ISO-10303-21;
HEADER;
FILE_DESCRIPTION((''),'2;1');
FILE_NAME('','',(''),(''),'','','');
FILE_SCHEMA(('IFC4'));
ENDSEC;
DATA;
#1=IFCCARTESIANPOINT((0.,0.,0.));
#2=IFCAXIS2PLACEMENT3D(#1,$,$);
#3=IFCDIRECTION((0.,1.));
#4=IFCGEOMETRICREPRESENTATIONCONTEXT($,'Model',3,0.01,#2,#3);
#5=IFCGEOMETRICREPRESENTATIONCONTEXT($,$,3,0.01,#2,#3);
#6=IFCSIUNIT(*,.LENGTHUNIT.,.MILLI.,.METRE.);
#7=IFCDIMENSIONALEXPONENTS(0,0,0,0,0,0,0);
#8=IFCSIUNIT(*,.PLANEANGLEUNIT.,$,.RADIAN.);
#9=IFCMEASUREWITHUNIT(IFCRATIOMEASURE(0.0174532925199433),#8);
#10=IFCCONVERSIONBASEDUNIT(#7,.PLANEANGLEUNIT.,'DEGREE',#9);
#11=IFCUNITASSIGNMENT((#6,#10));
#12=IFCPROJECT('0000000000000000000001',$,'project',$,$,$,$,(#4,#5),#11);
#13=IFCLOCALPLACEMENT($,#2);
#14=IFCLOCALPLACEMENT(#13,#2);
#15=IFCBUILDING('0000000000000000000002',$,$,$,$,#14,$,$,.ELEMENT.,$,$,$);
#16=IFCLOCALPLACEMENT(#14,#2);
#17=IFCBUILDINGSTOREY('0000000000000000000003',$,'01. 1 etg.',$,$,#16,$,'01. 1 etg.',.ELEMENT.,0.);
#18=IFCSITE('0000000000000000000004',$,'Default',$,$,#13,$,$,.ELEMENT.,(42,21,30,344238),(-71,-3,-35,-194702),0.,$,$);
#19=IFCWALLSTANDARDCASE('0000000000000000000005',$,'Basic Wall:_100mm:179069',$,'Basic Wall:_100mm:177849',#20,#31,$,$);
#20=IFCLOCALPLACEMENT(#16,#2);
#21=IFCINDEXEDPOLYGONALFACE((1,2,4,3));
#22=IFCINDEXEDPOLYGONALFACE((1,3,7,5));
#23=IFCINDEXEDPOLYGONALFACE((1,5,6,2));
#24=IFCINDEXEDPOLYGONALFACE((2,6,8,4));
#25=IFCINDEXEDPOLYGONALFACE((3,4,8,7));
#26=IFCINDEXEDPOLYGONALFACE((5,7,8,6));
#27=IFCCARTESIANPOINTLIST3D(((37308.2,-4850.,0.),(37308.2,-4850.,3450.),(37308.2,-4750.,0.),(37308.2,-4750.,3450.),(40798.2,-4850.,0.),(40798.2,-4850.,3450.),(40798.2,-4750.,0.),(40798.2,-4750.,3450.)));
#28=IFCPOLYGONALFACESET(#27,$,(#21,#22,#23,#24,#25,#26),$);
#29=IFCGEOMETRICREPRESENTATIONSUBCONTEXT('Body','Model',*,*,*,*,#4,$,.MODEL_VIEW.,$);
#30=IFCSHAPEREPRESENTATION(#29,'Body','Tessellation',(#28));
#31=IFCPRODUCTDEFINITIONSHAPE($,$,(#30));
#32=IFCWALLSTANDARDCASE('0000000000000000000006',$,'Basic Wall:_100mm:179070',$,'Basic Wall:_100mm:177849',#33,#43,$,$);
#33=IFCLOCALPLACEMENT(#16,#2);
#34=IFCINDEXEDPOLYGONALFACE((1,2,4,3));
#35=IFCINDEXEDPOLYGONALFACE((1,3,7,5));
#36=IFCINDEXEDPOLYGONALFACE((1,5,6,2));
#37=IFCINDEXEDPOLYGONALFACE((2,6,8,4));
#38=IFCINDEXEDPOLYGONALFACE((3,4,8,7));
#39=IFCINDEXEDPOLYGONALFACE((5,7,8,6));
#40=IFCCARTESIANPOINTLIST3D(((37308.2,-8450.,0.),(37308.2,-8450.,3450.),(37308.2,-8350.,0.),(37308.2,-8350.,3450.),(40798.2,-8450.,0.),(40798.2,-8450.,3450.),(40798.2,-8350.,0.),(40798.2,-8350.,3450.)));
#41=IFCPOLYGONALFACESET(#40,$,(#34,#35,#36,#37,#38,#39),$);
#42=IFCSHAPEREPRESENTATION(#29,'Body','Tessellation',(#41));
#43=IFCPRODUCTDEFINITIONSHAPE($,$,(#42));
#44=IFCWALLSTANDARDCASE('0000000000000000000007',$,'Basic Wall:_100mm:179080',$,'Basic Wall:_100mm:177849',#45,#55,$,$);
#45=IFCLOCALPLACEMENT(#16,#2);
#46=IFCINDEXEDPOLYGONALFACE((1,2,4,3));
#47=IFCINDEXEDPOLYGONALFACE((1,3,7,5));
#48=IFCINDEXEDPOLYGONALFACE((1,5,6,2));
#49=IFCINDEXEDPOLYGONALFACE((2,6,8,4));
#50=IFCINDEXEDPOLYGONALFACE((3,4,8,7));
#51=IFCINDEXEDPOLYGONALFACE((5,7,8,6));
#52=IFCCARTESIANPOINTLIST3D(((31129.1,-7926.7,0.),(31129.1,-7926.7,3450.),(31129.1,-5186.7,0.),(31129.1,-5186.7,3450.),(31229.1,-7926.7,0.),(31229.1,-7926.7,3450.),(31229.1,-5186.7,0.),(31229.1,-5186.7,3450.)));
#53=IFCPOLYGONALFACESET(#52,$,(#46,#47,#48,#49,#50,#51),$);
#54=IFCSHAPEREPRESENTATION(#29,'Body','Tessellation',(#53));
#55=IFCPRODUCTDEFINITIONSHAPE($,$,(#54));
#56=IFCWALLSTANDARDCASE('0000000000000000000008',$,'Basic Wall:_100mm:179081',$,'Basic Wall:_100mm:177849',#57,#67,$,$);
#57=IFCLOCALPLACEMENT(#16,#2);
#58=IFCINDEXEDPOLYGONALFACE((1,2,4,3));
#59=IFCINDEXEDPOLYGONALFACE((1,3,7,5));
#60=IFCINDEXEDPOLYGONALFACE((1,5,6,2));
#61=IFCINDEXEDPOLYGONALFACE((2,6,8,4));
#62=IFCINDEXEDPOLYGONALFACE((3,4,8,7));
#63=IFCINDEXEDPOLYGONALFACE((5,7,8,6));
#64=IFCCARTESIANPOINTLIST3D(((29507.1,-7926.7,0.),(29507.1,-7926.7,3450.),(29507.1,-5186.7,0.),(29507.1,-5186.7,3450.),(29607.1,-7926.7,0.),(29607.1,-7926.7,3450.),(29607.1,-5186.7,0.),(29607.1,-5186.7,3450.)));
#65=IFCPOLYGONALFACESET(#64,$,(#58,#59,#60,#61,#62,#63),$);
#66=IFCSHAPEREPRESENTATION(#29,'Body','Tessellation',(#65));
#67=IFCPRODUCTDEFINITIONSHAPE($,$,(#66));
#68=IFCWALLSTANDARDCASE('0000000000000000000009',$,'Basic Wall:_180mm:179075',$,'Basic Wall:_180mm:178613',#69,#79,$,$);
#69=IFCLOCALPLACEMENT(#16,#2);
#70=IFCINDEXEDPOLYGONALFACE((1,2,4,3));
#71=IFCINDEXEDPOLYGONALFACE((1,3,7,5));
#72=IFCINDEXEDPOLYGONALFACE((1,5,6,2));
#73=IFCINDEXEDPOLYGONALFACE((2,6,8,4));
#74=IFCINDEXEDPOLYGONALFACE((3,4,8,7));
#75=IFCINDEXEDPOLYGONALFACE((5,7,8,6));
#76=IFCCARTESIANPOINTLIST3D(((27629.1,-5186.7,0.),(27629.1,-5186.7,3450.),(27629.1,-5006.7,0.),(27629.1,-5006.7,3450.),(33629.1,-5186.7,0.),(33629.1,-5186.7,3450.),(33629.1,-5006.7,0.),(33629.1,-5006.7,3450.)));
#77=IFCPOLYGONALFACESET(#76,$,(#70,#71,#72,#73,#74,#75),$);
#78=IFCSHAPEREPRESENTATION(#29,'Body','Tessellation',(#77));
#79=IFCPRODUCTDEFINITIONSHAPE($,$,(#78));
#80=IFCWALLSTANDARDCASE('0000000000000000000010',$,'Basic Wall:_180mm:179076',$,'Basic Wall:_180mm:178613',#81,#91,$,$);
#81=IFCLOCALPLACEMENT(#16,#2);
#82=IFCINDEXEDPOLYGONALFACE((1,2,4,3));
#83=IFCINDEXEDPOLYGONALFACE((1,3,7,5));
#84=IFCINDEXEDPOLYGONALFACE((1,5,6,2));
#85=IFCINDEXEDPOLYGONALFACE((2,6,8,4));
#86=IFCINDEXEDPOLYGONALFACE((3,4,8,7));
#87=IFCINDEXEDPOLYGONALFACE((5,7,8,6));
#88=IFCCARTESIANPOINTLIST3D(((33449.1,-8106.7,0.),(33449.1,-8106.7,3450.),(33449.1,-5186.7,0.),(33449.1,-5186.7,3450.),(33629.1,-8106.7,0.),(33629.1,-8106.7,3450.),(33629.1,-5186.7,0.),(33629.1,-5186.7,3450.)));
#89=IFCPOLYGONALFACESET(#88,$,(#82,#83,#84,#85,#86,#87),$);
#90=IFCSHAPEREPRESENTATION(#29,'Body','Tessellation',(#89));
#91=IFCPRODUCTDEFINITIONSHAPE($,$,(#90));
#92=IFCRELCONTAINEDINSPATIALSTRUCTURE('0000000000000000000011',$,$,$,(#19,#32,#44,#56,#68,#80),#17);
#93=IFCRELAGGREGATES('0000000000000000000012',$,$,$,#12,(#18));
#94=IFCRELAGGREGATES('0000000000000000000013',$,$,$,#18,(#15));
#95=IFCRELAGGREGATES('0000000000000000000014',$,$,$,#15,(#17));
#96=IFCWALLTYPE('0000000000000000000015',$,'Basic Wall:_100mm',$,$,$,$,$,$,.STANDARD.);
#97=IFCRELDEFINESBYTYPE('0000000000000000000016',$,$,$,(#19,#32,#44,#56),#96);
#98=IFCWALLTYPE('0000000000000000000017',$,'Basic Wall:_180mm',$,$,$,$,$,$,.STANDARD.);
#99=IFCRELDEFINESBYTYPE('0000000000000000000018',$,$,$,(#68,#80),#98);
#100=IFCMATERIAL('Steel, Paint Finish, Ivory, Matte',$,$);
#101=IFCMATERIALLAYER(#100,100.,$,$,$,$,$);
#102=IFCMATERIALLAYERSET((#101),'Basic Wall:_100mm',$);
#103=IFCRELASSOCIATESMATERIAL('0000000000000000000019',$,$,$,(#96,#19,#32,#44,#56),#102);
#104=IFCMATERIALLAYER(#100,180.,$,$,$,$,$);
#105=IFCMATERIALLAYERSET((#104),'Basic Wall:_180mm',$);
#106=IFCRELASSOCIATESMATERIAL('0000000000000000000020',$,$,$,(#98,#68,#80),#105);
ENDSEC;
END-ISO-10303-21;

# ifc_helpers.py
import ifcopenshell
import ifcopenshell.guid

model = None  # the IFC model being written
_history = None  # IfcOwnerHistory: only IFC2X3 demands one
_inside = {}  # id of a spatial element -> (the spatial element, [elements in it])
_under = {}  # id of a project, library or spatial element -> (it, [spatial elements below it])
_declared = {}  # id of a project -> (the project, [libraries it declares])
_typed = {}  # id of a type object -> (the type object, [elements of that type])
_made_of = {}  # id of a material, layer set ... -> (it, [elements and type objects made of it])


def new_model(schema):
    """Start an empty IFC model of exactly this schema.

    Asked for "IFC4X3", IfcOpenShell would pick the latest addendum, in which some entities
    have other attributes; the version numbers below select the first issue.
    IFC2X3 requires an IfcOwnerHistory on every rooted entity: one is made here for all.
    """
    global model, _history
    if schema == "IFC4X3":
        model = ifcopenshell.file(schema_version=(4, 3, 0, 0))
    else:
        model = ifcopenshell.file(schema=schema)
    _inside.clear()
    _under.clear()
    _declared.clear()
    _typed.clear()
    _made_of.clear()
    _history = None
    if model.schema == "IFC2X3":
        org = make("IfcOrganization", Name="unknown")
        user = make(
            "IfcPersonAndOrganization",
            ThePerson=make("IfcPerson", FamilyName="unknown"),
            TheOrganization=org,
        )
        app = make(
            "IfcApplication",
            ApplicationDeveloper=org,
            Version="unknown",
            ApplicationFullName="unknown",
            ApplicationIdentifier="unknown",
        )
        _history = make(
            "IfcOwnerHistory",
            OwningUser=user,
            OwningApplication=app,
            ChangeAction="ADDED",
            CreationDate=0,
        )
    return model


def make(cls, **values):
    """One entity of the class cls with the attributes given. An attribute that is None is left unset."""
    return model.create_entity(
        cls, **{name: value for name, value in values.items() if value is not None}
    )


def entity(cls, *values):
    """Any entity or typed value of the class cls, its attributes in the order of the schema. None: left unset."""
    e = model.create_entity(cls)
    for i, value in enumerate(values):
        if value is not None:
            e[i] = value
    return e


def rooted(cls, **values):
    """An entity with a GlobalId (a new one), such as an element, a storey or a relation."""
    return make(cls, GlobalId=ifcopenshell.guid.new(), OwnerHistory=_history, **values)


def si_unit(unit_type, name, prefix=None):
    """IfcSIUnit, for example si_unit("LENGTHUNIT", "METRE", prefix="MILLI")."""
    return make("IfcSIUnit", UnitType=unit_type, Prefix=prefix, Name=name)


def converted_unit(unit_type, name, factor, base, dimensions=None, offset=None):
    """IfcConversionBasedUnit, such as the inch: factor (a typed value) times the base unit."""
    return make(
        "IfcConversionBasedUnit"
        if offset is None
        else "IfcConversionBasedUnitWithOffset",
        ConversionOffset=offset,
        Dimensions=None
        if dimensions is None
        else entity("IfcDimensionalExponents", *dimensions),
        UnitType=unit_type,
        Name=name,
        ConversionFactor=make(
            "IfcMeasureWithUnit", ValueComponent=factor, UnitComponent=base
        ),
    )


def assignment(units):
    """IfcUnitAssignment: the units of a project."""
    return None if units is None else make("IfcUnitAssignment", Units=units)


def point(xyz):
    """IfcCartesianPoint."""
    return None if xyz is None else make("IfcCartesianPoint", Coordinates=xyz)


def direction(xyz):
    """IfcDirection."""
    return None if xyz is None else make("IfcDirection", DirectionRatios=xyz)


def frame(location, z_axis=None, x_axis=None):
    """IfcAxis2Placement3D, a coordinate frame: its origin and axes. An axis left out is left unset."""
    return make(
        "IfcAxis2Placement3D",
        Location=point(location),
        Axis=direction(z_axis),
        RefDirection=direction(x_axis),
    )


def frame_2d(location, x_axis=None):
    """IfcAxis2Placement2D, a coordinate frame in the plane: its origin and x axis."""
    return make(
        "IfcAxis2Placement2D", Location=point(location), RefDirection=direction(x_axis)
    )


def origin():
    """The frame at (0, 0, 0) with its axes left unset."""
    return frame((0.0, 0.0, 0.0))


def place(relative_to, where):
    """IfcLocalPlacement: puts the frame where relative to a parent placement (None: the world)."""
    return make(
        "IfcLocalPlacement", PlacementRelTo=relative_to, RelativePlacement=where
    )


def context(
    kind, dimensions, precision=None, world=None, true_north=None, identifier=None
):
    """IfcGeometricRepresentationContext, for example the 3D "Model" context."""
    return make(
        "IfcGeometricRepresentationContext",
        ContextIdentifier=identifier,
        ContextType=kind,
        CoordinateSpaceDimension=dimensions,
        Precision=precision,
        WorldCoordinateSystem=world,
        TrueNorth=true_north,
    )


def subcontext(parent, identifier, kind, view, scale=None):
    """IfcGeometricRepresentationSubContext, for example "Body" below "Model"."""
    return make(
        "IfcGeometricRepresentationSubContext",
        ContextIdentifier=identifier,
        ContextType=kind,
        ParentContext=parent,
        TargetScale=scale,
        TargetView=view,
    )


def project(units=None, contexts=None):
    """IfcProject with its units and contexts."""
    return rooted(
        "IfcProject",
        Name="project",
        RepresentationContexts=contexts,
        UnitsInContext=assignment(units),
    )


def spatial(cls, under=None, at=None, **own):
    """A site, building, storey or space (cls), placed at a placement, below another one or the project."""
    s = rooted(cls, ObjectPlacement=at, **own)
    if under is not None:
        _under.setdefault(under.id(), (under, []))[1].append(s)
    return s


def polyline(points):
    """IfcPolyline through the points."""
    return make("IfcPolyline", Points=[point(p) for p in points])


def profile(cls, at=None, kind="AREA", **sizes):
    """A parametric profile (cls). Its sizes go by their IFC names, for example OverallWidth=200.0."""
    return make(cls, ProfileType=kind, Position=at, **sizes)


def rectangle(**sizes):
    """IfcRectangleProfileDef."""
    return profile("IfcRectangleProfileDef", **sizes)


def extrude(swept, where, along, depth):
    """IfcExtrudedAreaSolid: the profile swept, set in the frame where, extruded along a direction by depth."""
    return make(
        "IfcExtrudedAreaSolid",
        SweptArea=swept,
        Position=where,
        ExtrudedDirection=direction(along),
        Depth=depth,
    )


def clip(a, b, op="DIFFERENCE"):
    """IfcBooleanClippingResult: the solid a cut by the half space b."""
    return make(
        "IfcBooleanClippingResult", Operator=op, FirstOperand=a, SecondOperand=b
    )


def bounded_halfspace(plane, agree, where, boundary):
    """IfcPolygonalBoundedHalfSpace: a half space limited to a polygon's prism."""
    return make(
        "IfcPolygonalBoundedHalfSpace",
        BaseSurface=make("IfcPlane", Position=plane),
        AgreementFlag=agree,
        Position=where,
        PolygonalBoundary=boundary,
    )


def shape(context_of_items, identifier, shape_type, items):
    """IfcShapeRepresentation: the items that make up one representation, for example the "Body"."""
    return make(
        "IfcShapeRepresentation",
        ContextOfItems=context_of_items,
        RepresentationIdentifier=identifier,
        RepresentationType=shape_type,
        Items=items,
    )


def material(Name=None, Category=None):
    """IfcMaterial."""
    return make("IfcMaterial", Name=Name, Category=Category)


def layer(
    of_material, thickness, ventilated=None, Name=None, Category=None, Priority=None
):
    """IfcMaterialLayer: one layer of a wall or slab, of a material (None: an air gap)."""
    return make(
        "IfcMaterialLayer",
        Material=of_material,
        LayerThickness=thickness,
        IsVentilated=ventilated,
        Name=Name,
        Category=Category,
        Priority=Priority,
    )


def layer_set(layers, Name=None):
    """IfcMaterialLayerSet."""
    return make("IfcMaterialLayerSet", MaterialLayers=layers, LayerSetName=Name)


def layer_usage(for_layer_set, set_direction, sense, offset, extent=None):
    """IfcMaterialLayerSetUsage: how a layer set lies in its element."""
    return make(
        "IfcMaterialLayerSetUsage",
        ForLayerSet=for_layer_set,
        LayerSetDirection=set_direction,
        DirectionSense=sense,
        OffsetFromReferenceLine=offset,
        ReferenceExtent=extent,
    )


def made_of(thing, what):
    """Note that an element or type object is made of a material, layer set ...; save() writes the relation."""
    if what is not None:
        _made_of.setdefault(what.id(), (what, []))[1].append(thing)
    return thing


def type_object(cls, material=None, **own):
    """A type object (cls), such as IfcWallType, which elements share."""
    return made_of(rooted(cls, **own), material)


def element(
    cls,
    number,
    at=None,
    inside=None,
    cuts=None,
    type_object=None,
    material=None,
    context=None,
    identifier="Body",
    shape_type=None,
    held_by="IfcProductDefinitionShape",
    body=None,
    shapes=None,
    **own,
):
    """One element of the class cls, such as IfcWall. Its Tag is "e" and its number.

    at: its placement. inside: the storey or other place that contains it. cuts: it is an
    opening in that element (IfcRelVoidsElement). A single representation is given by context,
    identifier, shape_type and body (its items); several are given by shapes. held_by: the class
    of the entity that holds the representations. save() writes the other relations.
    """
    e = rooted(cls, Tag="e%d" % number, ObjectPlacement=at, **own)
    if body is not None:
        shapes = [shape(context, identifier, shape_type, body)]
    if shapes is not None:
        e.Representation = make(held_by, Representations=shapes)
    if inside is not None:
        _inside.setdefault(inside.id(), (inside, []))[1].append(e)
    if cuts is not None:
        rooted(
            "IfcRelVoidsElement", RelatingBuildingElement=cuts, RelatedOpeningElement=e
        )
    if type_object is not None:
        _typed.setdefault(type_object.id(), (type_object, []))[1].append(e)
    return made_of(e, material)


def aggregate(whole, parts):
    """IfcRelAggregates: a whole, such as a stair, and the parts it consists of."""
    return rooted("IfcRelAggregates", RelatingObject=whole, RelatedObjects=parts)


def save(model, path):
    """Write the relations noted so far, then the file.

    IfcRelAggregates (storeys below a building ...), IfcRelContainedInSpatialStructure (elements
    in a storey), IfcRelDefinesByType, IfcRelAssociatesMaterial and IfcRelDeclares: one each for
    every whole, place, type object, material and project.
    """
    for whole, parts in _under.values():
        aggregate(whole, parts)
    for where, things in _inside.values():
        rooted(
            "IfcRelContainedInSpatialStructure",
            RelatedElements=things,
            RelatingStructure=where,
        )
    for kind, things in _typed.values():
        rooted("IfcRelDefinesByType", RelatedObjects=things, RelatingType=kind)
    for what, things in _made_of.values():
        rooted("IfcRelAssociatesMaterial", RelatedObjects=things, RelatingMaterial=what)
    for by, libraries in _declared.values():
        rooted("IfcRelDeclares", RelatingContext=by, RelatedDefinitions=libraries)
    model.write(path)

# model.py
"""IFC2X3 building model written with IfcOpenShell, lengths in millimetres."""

from ifc_helpers import new_model, entity, si_unit, converted_unit, direction, frame, frame_2d, origin, place, context, subcontext, project, spatial, polyline, rectangle, extrude, clip, bounded_halfspace, material, layer, layer_set, layer_usage, type_object, element, save


model = new_model("IFC2X3")

# Units and contexts
model_context = context("Model", 3, precision=0.01, world=origin(), true_north=direction((0.0, 1.0)))
context_of_model = context(None, 3, precision=0.01, world=origin(), true_north=direction((0.0, 1.0)))
body_context = subcontext(model_context, "Body", "Model", "MODEL_VIEW")
ifc_project = project(units=[si_unit("LENGTHUNIT", "METRE", prefix="MILLI"), converted_unit("PLANEANGLEUNIT", "DEGREE", entity("IfcRatioMeasure", 0.0174532925199433), si_unit("PLANEANGLEUNIT", "RADIAN"), dimensions=[0, 0, 0, 0, 0, 0, 0])], contexts=[model_context, context_of_model])

# Site, building, storey
site_placement = place(None, origin())
site = spatial("IfcSite", under=ifc_project, at=site_placement, Name="Default", CompositionType="ELEMENT", RefLatitude=(42, 21, 30, 344238), RefLongitude=(-71, -3, -35, -194702), RefElevation=0.0)
building_placement = place(site_placement, origin())
building = spatial("IfcBuilding", under=site, at=building_placement, CompositionType="ELEMENT")
storey_placement = place(building_placement, origin())
storey = spatial("IfcBuildingStorey", under=building, at=storey_placement, Name="01. 1 etg.", LongName="01. 1 etg.", CompositionType="ELEMENT", Elevation=0.0)

# Shared definitions
ifc_material_1 = material(Name="Steel, Paint Finish, Ivory, Matte")
ifc_layer_1 = layer(ifc_material_1, 100.0)
ifc_layer_set_1 = layer_set([ifc_layer_1], Name="Basic Wall:_100mm")
wall_type_1 = type_object("IfcWallType", Name="Basic Wall:_100mm", PredefinedType="STANDARD", material=ifc_layer_set_1)

# Walls
ifc_layer_usage_1 = layer_usage(ifc_layer_set_1, "AXIS2", "POSITIVE", -50.0)
wall_1_placement = place(storey_placement, frame((37308.2, -4800.0, 0.0)))
element("IfcWallStandardCase", 1, at=wall_1_placement, inside=storey, type_object=wall_type_1, material=ifc_layer_usage_1, Name="Basic Wall:_100mm:179069", ObjectType="Basic Wall:_100mm:177849", context=body_context, shape_type="Clipping", body=[
    clip(extrude(rectangle(XDim=3490.0, YDim=100.0, at=frame_2d((1745.0, 0.0), x_axis=(-1.0, 0.0))), origin(), (0.0, 0.0, 1.0), 3450.0), bounded_halfspace(frame((0.0, -50.0, 3450.0), z_axis=(0.0, 0.0, -1.0), x_axis=(0.0, -1.0, 0.0)), True, frame((0.0, -50.0, 3450.0)), polyline([(0.0, 0.0), (3490.0, 0.0), (3490.0, 100.0), (0.0, 100.0), (0.0, 0.0)]))),
])
ifc_layer_usage_2 = layer_usage(ifc_layer_set_1, "AXIS2", "POSITIVE", -50.0)
wall_2_placement = place(storey_placement, frame((37308.2, -8400.0, 0.0)))
element("IfcWallStandardCase", 2, at=wall_2_placement, inside=storey, type_object=wall_type_1, material=ifc_layer_usage_2, Name="Basic Wall:_100mm:179070", ObjectType="Basic Wall:_100mm:177849", context=body_context, shape_type="Clipping", body=[
    clip(extrude(rectangle(XDim=3490.0, YDim=100.0, at=frame_2d((1745.0, 0.0), x_axis=(-1.0, 0.0))), origin(), (0.0, 0.0, 1.0), 3450.0), bounded_halfspace(frame((0.0, -50.0, 3450.0), z_axis=(0.0, 0.0, -1.0), x_axis=(0.0, -1.0, 0.0)), True, frame((0.0, -50.0, 3450.0)), polyline([(0.0, 0.0), (3490.0, 0.0), (3490.0, 100.0), (0.0, 100.0), (0.0, 0.0)]))),
])
ifc_layer_usage_3 = layer_usage(ifc_layer_set_1, "AXIS2", "NEGATIVE", 50.0)
wall_3_placement = place(storey_placement, frame((31179.1, -5186.7, 0.0), z_axis=(0.0, 0.0, 1.0), x_axis=(0.0, -1.0, 0.0)))
element("IfcWallStandardCase", 3, at=wall_3_placement, inside=storey, type_object=wall_type_1, material=ifc_layer_usage_3, Name="Basic Wall:_100mm:179080", ObjectType="Basic Wall:_100mm:177849", context=body_context, shape_type="Clipping", body=[
    clip(extrude(rectangle(XDim=2740.0, YDim=100.0, at=frame_2d((1370.0, 0.0), x_axis=(-1.0, 0.0))), origin(), (0.0, 0.0, 1.0), 3450.0), bounded_halfspace(frame((0.0, -50.0, 3450.0), z_axis=(0.0, 0.0, -1.0), x_axis=(1.0, 0.0, 0.0)), True, frame((0.0, -50.0, 3450.0)), polyline([(0.0, 0.0), (2740.0, 0.0), (2740.0, 100.0), (0.0, 100.0), (0.0, 0.0)]))),
])
ifc_layer_usage_4 = layer_usage(ifc_layer_set_1, "AXIS2", "POSITIVE", -50.0)
wall_4_placement = place(storey_placement, frame((29557.1, -5186.7, 0.0), z_axis=(0.0, 0.0, 1.0), x_axis=(0.0, -1.0, 0.0)))
element("IfcWallStandardCase", 4, at=wall_4_placement, inside=storey, type_object=wall_type_1, material=ifc_layer_usage_4, Name="Basic Wall:_100mm:179081", ObjectType="Basic Wall:_100mm:177849", context=body_context, shape_type="Clipping", body=[
    clip(extrude(rectangle(XDim=2740.0, YDim=100.0, at=frame_2d((1370.0, 0.0), x_axis=(-1.0, 0.0))), origin(), (0.0, 0.0, 1.0), 3450.0), bounded_halfspace(frame((0.0, -50.0, 3450.0), z_axis=(0.0, 0.0, -1.0), x_axis=(1.0, 0.0, 0.0)), True, frame((0.0, -50.0, 3450.0)), polyline([(0.0, 0.0), (2740.0, 0.0), (2740.0, 100.0), (0.0, 100.0), (0.0, 0.0)]))),
])
ifc_layer_2 = layer(ifc_material_1, 180.0)
ifc_layer_set_2 = layer_set([ifc_layer_2], Name="Basic Wall:_180mm")
ifc_layer_usage_5 = layer_usage(ifc_layer_set_2, "AXIS2", "POSITIVE", -90.0)
wall_type_2 = type_object("IfcWallType", Name="Basic Wall:_180mm", PredefinedType="STANDARD", material=ifc_layer_set_2)
wall_5_placement = place(storey_placement, frame((33629.1, -5096.7, 0.0), z_axis=(0.0, 0.0, 1.0), x_axis=(-1.0, 0.0, 0.0)))
element("IfcWallStandardCase", 5, at=wall_5_placement, inside=storey, type_object=wall_type_2, material=ifc_layer_usage_5, Name="Basic Wall:_180mm:179075", ObjectType="Basic Wall:_180mm:178613", context=body_context, shape_type="Clipping", body=[
    clip(extrude(rectangle(XDim=6000.0, YDim=180.0, at=frame_2d((3000.0, 0.0), x_axis=(-1.0, 0.0))), origin(), (0.0, 0.0, 1.0), 3450.0), bounded_halfspace(frame((0.0, -90.0, 3450.0), z_axis=(0.0, 0.0, -1.0), x_axis=(0.0, 1.0, 0.0)), True, frame((0.0, -90.0, 3450.0)), polyline([(0.0, 0.0), (6000.0, 0.0), (6000.0, 180.0), (5820.0, 180.0), (4122.0, 180.0), (4022.0, 180.0), (2500.0, 180.0), (2400.0, 180.0), (180.0, 180.0), (0.0, 180.0), (0.0, 0.0)]))),
])
ifc_layer_usage_6 = layer_usage(ifc_layer_set_2, "AXIS2", "POSITIVE", -90.0)
wall_6_placement = place(storey_placement, frame((33539.1, -8106.7, 0.0), z_axis=(0.0, 0.0, 1.0), x_axis=(0.0, 1.0, 0.0)))
element("IfcWallStandardCase", 6, at=wall_6_placement, inside=storey, type_object=wall_type_2, material=ifc_layer_usage_6, Name="Basic Wall:_180mm:179076", ObjectType="Basic Wall:_180mm:178613", context=body_context, shape_type="Clipping", body=[
    clip(extrude(rectangle(XDim=2920.0, YDim=180.0, at=frame_2d((1460.0, 0.0), x_axis=(-1.0, 0.0))), origin(), (0.0, 0.0, 1.0), 3450.0), bounded_halfspace(frame((0.0, -90.0, 3450.0), z_axis=(0.0, 0.0, -1.0), x_axis=(-1.0, 0.0, 0.0)), True, frame((0.0, -90.0, 3450.0)), polyline([(0.0, 0.0), (2920.0, 0.0), (2920.0, 180.0), (180.0, 180.0), (0.0, 180.0), (0.0, 0.0)]))),
])

save(model, "model.ifc")
